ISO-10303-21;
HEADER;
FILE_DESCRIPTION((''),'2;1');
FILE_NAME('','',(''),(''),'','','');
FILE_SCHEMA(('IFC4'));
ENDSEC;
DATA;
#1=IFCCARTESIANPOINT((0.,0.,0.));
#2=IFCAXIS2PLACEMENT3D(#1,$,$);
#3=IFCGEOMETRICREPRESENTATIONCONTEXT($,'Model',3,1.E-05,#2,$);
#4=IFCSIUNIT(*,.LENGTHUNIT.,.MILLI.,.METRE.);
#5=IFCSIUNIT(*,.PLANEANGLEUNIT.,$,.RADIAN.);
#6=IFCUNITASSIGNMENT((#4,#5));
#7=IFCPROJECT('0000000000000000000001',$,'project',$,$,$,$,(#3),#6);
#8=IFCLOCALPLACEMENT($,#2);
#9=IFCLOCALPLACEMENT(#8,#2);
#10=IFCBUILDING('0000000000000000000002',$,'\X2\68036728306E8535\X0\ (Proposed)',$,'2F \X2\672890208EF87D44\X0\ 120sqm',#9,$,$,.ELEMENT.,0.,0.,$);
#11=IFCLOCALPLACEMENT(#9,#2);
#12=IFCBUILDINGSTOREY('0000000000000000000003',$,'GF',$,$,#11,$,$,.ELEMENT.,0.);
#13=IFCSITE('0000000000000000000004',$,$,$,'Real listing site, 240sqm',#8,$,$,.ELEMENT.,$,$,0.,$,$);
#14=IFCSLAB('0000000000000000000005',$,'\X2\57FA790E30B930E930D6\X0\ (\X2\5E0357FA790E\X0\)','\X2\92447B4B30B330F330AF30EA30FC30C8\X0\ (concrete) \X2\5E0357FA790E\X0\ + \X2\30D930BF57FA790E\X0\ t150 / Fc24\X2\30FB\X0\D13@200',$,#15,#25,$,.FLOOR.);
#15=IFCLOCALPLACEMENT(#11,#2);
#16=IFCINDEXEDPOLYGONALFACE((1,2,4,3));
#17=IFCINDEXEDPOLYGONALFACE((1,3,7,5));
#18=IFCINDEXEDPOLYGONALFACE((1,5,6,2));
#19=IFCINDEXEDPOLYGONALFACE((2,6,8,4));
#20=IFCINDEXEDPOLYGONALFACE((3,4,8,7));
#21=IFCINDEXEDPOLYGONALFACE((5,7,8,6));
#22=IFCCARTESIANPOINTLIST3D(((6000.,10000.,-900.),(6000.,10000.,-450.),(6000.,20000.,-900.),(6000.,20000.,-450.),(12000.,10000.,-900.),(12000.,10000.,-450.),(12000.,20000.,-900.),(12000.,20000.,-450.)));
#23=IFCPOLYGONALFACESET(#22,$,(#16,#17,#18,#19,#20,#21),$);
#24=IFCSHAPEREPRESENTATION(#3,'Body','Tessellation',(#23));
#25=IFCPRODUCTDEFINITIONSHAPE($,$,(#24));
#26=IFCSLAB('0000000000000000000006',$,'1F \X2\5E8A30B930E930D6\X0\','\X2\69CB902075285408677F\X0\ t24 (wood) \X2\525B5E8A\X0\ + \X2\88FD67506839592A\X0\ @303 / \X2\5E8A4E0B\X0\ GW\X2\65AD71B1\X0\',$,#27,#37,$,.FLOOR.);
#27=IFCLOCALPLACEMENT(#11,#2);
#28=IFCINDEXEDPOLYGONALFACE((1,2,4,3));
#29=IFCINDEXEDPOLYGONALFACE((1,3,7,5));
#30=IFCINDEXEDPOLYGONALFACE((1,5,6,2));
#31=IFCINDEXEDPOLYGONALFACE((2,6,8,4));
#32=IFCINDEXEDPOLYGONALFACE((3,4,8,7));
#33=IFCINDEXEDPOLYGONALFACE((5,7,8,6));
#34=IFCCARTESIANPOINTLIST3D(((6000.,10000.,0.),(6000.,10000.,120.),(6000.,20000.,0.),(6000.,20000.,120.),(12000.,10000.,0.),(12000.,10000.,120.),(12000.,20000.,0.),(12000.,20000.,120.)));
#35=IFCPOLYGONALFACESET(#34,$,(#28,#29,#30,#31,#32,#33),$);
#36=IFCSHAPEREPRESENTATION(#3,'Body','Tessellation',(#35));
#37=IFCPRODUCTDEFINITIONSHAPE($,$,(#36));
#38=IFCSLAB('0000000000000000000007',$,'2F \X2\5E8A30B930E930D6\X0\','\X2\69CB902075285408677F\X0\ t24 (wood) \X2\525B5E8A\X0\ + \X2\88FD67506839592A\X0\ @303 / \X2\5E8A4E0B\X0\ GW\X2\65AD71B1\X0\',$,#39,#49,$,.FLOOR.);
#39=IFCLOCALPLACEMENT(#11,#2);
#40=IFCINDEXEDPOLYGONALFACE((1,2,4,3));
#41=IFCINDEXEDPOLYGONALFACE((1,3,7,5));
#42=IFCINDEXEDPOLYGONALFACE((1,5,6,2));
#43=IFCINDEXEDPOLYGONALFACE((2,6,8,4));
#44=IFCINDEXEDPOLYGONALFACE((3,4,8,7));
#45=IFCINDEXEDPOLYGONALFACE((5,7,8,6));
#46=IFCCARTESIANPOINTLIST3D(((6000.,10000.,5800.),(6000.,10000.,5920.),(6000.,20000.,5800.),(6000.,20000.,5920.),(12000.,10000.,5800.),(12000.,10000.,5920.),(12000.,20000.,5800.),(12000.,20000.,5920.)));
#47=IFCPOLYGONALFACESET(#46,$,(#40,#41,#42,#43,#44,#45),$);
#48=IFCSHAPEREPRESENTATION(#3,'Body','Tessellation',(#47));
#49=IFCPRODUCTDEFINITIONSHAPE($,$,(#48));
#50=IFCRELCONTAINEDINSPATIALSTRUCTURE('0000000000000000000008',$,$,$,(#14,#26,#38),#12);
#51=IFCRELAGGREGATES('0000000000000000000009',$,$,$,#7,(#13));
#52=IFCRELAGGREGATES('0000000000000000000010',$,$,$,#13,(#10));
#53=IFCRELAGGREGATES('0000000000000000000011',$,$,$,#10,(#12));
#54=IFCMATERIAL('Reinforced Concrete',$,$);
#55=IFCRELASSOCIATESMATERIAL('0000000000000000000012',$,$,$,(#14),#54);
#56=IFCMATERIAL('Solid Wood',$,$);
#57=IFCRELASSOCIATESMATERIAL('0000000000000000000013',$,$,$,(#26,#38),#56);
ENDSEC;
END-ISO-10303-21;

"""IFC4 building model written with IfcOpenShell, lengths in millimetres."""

from ifc_helpers import new_model, si_unit, frame, frame_2d, origin, place, context, project, spatial, rectangle, extrude, material, element, save


model = new_model("IFC4")

# Units and contexts
model_context = context("Model", 3, precision=1e-05, world=origin())
ifc_project = project(units=[si_unit("LENGTHUNIT", "METRE", prefix="MILLI"), si_unit("PLANEANGLEUNIT", "RADIAN")], contexts=[model_context])

# Site, building, storey
site_placement = place(None, origin())
site = spatial("IfcSite", under=ifc_project, at=site_placement, ObjectType="Real listing site, 240sqm", CompositionType="ELEMENT", RefElevation=0.0)
building_placement = place(site_placement, origin())
building = spatial("IfcBuilding", under=site, at=building_placement, Name="栃木の蔵 (Proposed)", ObjectType="2F 木造軸組 120sqm", CompositionType="ELEMENT", ElevationOfRefHeight=0.0, ElevationOfTerrain=0.0)
storey_placement = place(building_placement, origin())
storey = spatial("IfcBuildingStorey", under=building, at=storey_placement, Name="GF", CompositionType="ELEMENT", Elevation=0.0)

# Slabs
ifc_material_1 = material(Name="Reinforced Concrete")
slab_1_placement = place(storey_placement, frame((3000.0, 5000.0, -450.0)))
element("IfcSlab", 1, at=slab_1_placement, inside=storey, material=ifc_material_1, Name="基礎スラブ (布基礎)", Description="鉄筋コンクリート (concrete) 布基礎 + ベタ基礎 t150 / Fc24・D13@200", PredefinedType="FLOOR", context=model_context, shape_type="SweptSolid", body=[
    extrude(rectangle(XDim=6000.0, YDim=10000.0, at=frame_2d((3000.0, 5000.0))), frame((3000.0, 5000.0, -450.0)), (0.0, 0.0, 1.0), 450.0),
])
ifc_material_2 = material(Name="Solid Wood")
slab_2_placement = place(storey_placement, frame((3000.0, 5000.0, 0.0)))
element("IfcSlab", 2, at=slab_2_placement, inside=storey, material=ifc_material_2, Name="1F 床スラブ", Description="構造用合板 t24 (wood) 剛床 + 製材根太 @303 / 床下 GW断熱", PredefinedType="FLOOR", context=model_context, shape_type="SweptSolid", body=[
    extrude(rectangle(XDim=6000.0, YDim=10000.0, at=frame_2d((3000.0, 5000.0))), frame((3000.0, 5000.0, 0.0)), (0.0, 0.0, 1.0), 120.0),
])
slab_3_placement = place(storey_placement, frame((3000.0, 5000.0, 2900.0)))
element("IfcSlab", 3, at=slab_3_placement, inside=storey, material=ifc_material_2, Name="2F 床スラブ", Description="構造用合板 t24 (wood) 剛床 + 製材根太 @303 / 床下 GW断熱", PredefinedType="FLOOR", context=model_context, shape_type="SweptSolid", body=[
    extrude(rectangle(XDim=6000.0, YDim=10000.0, at=frame_2d((3000.0, 5000.0))), frame((3000.0, 5000.0, 2900.0)), (0.0, 0.0, 1.0), 120.0),
])

save(model, "model.ifc")
